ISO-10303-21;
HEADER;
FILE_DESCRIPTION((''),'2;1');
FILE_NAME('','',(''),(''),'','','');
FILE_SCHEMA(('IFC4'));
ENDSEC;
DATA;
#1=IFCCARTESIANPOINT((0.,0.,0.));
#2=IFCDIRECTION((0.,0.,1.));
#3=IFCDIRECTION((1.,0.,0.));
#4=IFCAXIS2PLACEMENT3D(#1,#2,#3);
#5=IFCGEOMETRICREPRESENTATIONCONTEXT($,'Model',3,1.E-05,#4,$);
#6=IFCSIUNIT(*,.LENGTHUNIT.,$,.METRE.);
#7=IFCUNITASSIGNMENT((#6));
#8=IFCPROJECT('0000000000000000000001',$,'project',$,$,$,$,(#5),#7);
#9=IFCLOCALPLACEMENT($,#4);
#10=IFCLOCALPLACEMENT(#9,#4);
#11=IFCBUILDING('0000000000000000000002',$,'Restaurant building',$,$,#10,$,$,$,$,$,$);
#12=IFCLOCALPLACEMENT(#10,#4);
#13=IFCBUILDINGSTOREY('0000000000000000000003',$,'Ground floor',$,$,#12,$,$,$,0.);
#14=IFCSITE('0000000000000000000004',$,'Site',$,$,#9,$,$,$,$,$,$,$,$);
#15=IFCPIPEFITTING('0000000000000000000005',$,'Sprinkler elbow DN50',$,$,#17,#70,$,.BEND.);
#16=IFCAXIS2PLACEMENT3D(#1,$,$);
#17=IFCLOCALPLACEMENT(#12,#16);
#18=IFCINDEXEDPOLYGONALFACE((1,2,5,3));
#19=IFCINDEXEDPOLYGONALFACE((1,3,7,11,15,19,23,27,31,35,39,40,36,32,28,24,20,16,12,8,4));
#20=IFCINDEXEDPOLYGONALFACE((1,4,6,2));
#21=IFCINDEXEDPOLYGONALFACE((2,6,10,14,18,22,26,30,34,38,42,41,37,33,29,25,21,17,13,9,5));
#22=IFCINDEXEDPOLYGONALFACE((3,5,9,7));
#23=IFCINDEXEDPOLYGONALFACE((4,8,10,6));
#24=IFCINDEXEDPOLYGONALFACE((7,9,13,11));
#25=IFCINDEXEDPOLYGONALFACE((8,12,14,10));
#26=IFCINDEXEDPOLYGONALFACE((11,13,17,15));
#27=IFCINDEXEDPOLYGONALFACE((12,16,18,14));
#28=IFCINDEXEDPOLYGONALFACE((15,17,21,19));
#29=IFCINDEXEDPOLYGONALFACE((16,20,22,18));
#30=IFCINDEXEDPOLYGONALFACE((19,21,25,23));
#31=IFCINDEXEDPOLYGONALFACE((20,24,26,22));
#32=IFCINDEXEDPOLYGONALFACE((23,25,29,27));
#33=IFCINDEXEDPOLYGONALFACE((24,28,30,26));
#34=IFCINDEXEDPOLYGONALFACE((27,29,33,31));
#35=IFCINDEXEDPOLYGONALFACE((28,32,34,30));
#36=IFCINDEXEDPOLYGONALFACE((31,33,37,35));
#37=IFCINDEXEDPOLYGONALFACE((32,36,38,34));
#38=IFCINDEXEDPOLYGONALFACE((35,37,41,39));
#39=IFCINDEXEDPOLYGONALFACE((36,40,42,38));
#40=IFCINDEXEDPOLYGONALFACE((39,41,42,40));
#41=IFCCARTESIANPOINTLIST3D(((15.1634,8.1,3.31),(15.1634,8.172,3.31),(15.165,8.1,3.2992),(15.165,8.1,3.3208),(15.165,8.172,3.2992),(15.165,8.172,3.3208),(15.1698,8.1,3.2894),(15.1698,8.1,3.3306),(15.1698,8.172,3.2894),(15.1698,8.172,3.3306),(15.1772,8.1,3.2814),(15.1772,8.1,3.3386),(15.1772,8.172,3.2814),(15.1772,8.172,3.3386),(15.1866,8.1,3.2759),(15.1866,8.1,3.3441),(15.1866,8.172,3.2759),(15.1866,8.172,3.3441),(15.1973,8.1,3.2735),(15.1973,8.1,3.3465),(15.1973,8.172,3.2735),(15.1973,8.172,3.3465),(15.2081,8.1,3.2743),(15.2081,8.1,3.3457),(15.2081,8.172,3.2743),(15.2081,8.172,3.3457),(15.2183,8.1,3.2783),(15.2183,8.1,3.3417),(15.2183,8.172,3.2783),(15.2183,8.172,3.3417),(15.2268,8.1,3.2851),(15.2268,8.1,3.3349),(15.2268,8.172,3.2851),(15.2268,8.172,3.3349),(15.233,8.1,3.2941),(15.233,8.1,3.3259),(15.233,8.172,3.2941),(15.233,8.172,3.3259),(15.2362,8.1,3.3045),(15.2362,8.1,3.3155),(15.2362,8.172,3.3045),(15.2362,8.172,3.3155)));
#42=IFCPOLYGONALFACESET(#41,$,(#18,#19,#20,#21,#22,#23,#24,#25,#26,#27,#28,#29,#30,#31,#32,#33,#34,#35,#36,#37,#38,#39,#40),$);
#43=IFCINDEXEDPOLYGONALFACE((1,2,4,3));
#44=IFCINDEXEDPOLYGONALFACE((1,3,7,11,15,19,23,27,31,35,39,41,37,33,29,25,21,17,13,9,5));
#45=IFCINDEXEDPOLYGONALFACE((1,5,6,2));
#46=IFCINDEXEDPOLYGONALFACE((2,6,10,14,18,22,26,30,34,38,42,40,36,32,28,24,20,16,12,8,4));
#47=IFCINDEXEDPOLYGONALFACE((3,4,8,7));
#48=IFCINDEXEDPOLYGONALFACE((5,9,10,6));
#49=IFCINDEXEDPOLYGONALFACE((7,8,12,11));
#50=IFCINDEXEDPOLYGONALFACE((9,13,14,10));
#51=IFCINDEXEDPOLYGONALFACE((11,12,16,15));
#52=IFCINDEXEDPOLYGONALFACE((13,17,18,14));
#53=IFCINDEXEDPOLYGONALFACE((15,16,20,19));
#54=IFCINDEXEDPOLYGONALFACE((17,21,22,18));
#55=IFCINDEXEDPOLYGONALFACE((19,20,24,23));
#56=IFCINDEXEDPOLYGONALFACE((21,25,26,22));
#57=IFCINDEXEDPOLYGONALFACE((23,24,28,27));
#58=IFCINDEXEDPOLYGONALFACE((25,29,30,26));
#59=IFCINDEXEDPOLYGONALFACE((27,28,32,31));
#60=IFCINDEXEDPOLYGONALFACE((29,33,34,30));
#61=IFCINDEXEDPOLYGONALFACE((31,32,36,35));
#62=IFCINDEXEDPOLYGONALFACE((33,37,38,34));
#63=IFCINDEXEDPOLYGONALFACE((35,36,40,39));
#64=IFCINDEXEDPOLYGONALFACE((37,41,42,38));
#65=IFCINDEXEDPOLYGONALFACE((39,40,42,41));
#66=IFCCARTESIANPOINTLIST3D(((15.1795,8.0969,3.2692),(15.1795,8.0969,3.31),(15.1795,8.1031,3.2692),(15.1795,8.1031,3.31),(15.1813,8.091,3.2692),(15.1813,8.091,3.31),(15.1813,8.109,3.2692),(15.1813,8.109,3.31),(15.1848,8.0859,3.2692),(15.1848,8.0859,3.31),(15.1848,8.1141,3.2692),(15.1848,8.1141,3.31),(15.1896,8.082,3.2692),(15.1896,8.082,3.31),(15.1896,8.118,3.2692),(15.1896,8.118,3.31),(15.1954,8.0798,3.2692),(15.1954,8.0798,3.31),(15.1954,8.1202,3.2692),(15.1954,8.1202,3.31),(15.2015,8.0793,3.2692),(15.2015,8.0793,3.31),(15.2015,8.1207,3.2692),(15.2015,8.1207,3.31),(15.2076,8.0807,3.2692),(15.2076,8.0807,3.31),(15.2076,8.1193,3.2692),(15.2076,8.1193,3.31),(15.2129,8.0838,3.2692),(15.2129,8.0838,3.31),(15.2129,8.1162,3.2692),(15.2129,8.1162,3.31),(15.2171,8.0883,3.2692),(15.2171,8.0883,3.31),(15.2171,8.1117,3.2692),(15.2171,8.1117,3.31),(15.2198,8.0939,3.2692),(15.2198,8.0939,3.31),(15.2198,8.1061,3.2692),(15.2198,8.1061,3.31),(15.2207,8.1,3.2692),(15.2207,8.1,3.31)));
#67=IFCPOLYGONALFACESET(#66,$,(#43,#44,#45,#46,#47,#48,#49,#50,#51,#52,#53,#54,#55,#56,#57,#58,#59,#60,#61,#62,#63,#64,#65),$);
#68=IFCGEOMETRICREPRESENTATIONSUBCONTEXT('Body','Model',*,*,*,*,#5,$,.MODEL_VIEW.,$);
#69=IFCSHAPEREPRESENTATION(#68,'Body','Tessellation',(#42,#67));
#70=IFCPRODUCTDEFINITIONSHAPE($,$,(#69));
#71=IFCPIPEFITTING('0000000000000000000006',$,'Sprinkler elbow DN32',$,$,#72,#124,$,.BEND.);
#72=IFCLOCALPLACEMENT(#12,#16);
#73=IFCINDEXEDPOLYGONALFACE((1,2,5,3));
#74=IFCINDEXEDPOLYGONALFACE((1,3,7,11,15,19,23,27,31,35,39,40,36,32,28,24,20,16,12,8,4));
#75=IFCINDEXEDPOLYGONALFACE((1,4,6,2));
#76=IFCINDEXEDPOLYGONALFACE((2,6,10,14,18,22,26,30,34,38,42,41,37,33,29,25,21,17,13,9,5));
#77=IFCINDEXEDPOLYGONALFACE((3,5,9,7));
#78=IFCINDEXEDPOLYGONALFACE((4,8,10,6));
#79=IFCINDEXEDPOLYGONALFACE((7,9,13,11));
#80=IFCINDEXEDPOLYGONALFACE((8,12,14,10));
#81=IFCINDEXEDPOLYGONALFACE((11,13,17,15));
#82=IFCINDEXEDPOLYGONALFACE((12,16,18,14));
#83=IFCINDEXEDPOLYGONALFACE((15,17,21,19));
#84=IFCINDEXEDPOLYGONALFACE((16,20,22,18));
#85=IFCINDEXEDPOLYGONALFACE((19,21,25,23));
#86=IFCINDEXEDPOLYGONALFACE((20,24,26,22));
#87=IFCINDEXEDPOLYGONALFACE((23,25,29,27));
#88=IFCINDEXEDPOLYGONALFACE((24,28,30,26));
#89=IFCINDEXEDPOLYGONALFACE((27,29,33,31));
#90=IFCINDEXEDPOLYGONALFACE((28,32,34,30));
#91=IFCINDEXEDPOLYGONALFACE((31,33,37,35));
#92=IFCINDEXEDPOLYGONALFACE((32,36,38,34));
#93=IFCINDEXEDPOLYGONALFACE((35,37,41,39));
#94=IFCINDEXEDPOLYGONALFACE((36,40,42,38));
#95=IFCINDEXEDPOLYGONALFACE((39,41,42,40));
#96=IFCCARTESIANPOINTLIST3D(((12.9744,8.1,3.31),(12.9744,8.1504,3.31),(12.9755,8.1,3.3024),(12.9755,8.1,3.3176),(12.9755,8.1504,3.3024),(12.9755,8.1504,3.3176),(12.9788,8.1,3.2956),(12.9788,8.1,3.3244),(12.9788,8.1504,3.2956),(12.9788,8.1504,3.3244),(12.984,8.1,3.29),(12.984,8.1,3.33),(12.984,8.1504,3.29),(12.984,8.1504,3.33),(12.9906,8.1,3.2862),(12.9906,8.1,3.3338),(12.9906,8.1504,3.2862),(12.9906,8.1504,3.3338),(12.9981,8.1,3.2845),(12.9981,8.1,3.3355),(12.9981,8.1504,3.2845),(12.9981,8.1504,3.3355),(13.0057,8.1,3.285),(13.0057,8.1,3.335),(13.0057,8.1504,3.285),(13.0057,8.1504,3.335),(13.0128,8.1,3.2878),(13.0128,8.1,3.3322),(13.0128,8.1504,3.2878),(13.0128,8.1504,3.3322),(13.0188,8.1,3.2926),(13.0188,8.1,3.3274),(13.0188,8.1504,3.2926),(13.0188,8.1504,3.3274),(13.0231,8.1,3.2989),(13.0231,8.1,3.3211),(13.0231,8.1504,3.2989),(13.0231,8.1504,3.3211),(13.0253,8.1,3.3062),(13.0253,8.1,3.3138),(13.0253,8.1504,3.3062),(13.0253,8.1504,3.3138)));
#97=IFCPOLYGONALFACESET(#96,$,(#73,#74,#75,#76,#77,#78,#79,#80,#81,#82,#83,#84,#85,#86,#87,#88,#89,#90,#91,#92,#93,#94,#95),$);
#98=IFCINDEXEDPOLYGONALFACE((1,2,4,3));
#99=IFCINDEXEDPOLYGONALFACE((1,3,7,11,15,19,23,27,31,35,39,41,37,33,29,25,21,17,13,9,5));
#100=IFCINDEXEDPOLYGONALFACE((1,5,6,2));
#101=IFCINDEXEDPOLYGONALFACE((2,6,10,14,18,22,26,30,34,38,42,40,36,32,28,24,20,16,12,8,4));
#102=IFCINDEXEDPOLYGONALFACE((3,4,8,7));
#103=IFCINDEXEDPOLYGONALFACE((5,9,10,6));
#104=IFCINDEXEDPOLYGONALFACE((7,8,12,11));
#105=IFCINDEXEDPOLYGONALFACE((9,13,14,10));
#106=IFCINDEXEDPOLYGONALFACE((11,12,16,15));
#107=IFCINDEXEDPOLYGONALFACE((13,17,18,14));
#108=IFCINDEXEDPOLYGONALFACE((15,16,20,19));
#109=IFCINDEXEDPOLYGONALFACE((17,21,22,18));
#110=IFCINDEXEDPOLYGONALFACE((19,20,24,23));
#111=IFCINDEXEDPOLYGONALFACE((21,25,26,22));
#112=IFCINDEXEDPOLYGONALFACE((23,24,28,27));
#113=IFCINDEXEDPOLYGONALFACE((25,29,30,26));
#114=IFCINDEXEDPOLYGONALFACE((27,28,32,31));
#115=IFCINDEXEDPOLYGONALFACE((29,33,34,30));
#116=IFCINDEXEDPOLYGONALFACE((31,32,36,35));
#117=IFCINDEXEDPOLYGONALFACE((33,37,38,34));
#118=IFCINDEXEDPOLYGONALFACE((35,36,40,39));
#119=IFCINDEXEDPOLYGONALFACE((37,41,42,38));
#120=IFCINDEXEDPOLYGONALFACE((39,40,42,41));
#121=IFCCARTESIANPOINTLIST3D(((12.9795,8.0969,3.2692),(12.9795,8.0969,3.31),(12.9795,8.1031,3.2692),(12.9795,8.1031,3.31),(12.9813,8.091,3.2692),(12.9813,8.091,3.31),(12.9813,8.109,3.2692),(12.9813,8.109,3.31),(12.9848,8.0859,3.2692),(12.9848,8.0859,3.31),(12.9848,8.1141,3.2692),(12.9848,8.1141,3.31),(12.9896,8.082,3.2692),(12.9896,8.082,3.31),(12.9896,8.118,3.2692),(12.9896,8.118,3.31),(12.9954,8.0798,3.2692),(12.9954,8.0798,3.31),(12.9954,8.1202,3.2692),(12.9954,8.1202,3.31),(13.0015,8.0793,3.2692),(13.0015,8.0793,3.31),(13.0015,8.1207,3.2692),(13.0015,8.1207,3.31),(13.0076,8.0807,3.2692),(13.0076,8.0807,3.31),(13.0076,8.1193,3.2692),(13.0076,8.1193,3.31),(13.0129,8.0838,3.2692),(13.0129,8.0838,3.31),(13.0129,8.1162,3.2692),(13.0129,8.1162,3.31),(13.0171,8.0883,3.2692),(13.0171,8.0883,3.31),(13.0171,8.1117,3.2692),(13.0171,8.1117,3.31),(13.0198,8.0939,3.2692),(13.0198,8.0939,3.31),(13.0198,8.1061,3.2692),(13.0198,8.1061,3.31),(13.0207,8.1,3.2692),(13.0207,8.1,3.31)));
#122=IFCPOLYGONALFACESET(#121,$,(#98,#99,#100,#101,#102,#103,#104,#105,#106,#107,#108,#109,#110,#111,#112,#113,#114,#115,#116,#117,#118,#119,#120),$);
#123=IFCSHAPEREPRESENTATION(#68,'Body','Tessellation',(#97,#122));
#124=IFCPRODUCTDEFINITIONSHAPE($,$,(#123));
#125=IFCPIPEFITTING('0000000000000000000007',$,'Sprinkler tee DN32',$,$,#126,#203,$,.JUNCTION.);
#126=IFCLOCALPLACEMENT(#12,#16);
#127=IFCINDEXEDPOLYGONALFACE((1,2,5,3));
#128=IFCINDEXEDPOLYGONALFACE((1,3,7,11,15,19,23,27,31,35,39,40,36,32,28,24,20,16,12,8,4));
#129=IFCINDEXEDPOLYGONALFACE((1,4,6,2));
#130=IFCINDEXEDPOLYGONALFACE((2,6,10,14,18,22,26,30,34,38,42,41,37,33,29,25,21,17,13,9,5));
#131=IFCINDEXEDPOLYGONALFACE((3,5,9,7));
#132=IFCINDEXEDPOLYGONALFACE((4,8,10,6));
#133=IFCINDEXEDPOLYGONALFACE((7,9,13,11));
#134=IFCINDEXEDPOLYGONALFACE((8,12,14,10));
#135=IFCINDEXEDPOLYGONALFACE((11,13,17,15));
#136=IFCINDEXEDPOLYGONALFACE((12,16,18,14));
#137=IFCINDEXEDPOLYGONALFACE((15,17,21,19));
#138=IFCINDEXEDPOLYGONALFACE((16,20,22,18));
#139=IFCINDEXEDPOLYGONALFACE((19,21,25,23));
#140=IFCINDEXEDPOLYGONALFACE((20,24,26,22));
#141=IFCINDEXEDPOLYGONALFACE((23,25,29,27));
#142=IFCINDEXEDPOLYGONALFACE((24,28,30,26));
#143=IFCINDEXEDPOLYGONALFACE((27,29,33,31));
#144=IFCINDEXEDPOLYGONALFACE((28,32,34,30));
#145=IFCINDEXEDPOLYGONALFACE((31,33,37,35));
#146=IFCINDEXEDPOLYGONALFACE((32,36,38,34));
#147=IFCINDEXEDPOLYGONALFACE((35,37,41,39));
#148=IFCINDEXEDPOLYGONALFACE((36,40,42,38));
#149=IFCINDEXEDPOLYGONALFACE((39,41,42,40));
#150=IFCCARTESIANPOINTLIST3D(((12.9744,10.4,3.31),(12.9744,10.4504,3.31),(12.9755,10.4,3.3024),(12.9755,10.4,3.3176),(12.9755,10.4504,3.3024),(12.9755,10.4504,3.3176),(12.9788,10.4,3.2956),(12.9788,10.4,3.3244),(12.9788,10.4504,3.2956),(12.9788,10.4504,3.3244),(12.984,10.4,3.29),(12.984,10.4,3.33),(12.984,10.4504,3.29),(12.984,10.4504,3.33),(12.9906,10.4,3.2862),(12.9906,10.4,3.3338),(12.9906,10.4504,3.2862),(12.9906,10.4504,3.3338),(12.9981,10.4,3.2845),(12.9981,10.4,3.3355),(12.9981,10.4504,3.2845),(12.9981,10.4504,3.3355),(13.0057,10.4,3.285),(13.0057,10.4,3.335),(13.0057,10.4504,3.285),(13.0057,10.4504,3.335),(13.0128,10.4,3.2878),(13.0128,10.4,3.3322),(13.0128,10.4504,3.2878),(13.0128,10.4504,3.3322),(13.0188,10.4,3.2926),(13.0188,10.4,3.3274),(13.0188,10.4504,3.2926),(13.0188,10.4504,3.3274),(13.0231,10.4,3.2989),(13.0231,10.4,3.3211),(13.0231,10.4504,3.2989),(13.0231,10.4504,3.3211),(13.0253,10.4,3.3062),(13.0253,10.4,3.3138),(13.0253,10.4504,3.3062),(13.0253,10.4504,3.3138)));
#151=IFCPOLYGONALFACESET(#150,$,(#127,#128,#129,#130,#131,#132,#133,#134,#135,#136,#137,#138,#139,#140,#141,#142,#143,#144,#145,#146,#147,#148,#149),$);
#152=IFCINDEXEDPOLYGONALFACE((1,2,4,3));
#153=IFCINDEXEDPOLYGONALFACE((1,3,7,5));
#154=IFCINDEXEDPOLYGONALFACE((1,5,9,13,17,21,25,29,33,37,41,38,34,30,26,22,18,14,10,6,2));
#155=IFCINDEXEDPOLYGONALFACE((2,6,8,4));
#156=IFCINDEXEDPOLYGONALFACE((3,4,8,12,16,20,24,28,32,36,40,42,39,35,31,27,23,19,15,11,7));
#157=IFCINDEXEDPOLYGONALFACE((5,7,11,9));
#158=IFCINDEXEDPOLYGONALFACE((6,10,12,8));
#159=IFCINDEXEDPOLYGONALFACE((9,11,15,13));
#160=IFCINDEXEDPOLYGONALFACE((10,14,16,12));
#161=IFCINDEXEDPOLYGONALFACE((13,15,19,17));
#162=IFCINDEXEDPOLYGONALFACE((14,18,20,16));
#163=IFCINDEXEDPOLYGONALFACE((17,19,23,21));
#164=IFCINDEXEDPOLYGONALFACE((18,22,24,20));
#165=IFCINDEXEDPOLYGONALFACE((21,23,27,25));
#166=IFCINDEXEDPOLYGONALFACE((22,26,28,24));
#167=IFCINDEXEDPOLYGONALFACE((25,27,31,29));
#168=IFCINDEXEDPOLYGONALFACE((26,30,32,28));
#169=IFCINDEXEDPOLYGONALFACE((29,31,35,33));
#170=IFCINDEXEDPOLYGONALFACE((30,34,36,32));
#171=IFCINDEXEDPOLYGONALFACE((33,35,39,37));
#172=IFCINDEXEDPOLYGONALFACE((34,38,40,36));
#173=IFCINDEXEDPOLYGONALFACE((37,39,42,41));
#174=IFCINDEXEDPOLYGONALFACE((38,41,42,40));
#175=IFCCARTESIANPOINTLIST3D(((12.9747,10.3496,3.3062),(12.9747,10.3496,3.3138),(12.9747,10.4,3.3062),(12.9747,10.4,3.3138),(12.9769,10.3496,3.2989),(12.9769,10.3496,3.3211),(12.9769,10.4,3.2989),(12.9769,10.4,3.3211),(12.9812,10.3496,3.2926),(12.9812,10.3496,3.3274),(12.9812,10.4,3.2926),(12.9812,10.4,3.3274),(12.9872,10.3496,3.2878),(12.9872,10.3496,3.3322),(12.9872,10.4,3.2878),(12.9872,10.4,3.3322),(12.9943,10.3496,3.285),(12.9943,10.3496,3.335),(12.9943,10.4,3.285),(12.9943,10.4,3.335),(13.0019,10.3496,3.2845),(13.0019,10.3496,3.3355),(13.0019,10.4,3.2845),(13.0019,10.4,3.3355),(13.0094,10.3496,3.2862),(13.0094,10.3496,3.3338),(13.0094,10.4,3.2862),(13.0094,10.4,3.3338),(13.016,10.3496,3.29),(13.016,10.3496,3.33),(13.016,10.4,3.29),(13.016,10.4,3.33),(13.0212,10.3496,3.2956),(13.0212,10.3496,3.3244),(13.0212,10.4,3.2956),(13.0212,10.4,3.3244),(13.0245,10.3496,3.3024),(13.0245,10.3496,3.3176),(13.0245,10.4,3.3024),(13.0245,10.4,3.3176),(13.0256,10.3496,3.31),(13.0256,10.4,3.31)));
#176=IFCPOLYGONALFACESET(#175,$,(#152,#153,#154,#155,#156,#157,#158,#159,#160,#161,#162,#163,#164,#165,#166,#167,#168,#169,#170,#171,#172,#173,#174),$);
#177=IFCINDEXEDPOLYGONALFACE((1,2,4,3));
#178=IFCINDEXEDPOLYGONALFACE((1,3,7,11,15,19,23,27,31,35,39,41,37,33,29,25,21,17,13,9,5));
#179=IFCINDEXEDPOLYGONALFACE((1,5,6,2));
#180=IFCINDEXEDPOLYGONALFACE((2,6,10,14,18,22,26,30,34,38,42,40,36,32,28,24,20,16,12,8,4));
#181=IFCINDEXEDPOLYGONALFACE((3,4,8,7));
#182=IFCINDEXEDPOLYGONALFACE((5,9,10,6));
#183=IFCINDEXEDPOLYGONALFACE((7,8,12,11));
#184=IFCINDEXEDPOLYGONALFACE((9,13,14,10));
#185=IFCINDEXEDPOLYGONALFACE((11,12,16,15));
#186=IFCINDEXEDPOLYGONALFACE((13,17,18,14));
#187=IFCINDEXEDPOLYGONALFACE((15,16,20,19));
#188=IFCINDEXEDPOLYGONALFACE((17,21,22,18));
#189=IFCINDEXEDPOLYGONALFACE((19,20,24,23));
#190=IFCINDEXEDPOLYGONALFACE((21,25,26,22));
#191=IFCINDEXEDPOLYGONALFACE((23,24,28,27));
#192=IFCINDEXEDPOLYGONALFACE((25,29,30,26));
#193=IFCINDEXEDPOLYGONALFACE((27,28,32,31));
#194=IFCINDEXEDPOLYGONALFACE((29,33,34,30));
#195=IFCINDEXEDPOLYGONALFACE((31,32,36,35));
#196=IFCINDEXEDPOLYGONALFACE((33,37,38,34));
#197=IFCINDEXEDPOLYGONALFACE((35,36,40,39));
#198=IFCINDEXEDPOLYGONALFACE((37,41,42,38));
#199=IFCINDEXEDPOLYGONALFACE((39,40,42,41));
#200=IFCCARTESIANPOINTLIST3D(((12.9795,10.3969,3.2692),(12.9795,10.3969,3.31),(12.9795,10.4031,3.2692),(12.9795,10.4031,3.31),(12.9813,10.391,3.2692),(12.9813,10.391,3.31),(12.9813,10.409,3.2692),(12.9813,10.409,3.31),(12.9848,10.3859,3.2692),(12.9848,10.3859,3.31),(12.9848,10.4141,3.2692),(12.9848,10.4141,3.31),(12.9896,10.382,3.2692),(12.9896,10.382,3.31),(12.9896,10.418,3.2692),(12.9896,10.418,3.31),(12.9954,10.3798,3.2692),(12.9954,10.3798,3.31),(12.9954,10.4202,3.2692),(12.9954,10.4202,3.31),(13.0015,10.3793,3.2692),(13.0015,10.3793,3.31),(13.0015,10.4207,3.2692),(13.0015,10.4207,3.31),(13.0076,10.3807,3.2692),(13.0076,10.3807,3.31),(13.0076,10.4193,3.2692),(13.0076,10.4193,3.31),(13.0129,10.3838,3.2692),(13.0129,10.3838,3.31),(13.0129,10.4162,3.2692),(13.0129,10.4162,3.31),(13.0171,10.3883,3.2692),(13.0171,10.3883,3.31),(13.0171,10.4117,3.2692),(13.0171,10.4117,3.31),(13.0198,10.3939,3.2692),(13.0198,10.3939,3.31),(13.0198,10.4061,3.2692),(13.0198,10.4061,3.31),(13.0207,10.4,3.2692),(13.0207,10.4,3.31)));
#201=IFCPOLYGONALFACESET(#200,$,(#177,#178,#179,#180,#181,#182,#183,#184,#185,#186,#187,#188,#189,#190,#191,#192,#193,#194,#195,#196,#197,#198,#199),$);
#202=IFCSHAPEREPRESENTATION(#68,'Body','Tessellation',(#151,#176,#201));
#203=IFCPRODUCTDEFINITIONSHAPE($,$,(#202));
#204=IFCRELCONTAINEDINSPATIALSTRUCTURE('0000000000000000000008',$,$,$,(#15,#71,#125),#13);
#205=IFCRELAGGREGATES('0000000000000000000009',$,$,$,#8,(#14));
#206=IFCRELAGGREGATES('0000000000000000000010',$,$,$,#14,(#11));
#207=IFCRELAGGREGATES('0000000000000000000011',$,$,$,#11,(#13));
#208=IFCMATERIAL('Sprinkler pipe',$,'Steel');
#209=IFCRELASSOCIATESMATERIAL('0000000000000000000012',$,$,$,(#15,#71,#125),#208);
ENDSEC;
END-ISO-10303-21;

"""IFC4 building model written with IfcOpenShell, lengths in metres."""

from ifc_helpers import new_model, si_unit, frame, origin_with_axes, origin_2d, place, context, subcontext, project, spatial, circle, extrude, material, element, save


model = new_model("IFC4")

# Units and contexts
model_context = context("Model", 3, precision=1e-05, world=origin_with_axes())
body_context = subcontext(model_context, "Body", "Model", "MODEL_VIEW")
ifc_project = project(units=[si_unit("LENGTHUNIT", "METRE")], contexts=[model_context])

# Site, building, storey
site_placement = place(None, origin_with_axes())
site = spatial("IfcSite", under=ifc_project, at=site_placement, Name="Site")
building_placement = place(site_placement, origin_with_axes())
building = spatial("IfcBuilding", under=site, at=building_placement, Name="Restaurant building")
storey_placement = place(building_placement, origin_with_axes())
storey = spatial("IfcBuildingStorey", under=building, at=storey_placement, Name="Ground floor", Elevation=0.0)

# Shared definitions
ifc_material_1 = material(Name="Sprinkler pipe", Category="Steel")

# Pipe fittings
pipe_fitting_1_placement = place(storey_placement, frame((15.2, 8.1, 3.31)))
element("IfcPipeFitting", 1, at=pipe_fitting_1_placement, inside=storey, material=ifc_material_1, Name="Sprinkler elbow DN50", PredefinedType="BEND", context=body_context, shape_type="SweptSolid", body=[
    extrude(circle(Radius=0.0366, at=origin_2d()), frame((0.0, 0.0, 0.0), z_axis=(0.0, 1.0, 0.0), x_axis=(-1.0, 0.0, 0.0)), (0.0, 0.0, 1.0), 0.072),
    extrude(circle(Radius=0.0207, at=origin_2d()), frame((0.0, 0.0, 0.0), z_axis=(0.0, 0.0, -1.0), x_axis=(1.0, 0.0, 0.0)), (0.0, 0.0, 1.0), 0.0408),
])
pipe_fitting_2_placement = place(storey_placement, frame((13.0, 8.1, 3.31)))
element("IfcPipeFitting", 2, at=pipe_fitting_2_placement, inside=storey, material=ifc_material_1, Name="Sprinkler elbow DN32", PredefinedType="BEND", context=body_context, shape_type="SweptSolid", body=[
    extrude(circle(Radius=0.0256, at=origin_2d()), frame((0.0, 0.0, 0.0), z_axis=(0.0, 1.0, 0.0), x_axis=(-1.0, 0.0, 0.0)), (0.0, 0.0, 1.0), 0.0504),
    extrude(circle(Radius=0.0207, at=origin_2d()), frame((0.0, 0.0, 0.0), z_axis=(0.0, 0.0, -1.0), x_axis=(1.0, 0.0, 0.0)), (0.0, 0.0, 1.0), 0.0408),
])
pipe_fitting_3_placement = place(storey_placement, frame((13.0, 10.4, 3.31)))
element("IfcPipeFitting", 3, at=pipe_fitting_3_placement, inside=storey, material=ifc_material_1, Name="Sprinkler tee DN32", PredefinedType="JUNCTION", context=body_context, shape_type="SweptSolid", body=[
    extrude(circle(Radius=0.0256, at=origin_2d()), frame((0.0, 0.0, 0.0), z_axis=(0.0, 1.0, 0.0), x_axis=(-1.0, 0.0, 0.0)), (0.0, 0.0, 1.0), 0.0504),
    extrude(circle(Radius=0.0256, at=origin_2d()), frame((0.0, 0.0, 0.0), z_axis=(0.0, -1.0, 0.0), x_axis=(1.0, 0.0, 0.0)), (0.0, 0.0, 1.0), 0.0504),
    extrude(circle(Radius=0.0207, at=origin_2d()), frame((0.0, 0.0, 0.0), z_axis=(0.0, 0.0, -1.0), x_axis=(1.0, 0.0, 0.0)), (0.0, 0.0, 1.0), 0.0408),
])

save(model, "model.ifc")
